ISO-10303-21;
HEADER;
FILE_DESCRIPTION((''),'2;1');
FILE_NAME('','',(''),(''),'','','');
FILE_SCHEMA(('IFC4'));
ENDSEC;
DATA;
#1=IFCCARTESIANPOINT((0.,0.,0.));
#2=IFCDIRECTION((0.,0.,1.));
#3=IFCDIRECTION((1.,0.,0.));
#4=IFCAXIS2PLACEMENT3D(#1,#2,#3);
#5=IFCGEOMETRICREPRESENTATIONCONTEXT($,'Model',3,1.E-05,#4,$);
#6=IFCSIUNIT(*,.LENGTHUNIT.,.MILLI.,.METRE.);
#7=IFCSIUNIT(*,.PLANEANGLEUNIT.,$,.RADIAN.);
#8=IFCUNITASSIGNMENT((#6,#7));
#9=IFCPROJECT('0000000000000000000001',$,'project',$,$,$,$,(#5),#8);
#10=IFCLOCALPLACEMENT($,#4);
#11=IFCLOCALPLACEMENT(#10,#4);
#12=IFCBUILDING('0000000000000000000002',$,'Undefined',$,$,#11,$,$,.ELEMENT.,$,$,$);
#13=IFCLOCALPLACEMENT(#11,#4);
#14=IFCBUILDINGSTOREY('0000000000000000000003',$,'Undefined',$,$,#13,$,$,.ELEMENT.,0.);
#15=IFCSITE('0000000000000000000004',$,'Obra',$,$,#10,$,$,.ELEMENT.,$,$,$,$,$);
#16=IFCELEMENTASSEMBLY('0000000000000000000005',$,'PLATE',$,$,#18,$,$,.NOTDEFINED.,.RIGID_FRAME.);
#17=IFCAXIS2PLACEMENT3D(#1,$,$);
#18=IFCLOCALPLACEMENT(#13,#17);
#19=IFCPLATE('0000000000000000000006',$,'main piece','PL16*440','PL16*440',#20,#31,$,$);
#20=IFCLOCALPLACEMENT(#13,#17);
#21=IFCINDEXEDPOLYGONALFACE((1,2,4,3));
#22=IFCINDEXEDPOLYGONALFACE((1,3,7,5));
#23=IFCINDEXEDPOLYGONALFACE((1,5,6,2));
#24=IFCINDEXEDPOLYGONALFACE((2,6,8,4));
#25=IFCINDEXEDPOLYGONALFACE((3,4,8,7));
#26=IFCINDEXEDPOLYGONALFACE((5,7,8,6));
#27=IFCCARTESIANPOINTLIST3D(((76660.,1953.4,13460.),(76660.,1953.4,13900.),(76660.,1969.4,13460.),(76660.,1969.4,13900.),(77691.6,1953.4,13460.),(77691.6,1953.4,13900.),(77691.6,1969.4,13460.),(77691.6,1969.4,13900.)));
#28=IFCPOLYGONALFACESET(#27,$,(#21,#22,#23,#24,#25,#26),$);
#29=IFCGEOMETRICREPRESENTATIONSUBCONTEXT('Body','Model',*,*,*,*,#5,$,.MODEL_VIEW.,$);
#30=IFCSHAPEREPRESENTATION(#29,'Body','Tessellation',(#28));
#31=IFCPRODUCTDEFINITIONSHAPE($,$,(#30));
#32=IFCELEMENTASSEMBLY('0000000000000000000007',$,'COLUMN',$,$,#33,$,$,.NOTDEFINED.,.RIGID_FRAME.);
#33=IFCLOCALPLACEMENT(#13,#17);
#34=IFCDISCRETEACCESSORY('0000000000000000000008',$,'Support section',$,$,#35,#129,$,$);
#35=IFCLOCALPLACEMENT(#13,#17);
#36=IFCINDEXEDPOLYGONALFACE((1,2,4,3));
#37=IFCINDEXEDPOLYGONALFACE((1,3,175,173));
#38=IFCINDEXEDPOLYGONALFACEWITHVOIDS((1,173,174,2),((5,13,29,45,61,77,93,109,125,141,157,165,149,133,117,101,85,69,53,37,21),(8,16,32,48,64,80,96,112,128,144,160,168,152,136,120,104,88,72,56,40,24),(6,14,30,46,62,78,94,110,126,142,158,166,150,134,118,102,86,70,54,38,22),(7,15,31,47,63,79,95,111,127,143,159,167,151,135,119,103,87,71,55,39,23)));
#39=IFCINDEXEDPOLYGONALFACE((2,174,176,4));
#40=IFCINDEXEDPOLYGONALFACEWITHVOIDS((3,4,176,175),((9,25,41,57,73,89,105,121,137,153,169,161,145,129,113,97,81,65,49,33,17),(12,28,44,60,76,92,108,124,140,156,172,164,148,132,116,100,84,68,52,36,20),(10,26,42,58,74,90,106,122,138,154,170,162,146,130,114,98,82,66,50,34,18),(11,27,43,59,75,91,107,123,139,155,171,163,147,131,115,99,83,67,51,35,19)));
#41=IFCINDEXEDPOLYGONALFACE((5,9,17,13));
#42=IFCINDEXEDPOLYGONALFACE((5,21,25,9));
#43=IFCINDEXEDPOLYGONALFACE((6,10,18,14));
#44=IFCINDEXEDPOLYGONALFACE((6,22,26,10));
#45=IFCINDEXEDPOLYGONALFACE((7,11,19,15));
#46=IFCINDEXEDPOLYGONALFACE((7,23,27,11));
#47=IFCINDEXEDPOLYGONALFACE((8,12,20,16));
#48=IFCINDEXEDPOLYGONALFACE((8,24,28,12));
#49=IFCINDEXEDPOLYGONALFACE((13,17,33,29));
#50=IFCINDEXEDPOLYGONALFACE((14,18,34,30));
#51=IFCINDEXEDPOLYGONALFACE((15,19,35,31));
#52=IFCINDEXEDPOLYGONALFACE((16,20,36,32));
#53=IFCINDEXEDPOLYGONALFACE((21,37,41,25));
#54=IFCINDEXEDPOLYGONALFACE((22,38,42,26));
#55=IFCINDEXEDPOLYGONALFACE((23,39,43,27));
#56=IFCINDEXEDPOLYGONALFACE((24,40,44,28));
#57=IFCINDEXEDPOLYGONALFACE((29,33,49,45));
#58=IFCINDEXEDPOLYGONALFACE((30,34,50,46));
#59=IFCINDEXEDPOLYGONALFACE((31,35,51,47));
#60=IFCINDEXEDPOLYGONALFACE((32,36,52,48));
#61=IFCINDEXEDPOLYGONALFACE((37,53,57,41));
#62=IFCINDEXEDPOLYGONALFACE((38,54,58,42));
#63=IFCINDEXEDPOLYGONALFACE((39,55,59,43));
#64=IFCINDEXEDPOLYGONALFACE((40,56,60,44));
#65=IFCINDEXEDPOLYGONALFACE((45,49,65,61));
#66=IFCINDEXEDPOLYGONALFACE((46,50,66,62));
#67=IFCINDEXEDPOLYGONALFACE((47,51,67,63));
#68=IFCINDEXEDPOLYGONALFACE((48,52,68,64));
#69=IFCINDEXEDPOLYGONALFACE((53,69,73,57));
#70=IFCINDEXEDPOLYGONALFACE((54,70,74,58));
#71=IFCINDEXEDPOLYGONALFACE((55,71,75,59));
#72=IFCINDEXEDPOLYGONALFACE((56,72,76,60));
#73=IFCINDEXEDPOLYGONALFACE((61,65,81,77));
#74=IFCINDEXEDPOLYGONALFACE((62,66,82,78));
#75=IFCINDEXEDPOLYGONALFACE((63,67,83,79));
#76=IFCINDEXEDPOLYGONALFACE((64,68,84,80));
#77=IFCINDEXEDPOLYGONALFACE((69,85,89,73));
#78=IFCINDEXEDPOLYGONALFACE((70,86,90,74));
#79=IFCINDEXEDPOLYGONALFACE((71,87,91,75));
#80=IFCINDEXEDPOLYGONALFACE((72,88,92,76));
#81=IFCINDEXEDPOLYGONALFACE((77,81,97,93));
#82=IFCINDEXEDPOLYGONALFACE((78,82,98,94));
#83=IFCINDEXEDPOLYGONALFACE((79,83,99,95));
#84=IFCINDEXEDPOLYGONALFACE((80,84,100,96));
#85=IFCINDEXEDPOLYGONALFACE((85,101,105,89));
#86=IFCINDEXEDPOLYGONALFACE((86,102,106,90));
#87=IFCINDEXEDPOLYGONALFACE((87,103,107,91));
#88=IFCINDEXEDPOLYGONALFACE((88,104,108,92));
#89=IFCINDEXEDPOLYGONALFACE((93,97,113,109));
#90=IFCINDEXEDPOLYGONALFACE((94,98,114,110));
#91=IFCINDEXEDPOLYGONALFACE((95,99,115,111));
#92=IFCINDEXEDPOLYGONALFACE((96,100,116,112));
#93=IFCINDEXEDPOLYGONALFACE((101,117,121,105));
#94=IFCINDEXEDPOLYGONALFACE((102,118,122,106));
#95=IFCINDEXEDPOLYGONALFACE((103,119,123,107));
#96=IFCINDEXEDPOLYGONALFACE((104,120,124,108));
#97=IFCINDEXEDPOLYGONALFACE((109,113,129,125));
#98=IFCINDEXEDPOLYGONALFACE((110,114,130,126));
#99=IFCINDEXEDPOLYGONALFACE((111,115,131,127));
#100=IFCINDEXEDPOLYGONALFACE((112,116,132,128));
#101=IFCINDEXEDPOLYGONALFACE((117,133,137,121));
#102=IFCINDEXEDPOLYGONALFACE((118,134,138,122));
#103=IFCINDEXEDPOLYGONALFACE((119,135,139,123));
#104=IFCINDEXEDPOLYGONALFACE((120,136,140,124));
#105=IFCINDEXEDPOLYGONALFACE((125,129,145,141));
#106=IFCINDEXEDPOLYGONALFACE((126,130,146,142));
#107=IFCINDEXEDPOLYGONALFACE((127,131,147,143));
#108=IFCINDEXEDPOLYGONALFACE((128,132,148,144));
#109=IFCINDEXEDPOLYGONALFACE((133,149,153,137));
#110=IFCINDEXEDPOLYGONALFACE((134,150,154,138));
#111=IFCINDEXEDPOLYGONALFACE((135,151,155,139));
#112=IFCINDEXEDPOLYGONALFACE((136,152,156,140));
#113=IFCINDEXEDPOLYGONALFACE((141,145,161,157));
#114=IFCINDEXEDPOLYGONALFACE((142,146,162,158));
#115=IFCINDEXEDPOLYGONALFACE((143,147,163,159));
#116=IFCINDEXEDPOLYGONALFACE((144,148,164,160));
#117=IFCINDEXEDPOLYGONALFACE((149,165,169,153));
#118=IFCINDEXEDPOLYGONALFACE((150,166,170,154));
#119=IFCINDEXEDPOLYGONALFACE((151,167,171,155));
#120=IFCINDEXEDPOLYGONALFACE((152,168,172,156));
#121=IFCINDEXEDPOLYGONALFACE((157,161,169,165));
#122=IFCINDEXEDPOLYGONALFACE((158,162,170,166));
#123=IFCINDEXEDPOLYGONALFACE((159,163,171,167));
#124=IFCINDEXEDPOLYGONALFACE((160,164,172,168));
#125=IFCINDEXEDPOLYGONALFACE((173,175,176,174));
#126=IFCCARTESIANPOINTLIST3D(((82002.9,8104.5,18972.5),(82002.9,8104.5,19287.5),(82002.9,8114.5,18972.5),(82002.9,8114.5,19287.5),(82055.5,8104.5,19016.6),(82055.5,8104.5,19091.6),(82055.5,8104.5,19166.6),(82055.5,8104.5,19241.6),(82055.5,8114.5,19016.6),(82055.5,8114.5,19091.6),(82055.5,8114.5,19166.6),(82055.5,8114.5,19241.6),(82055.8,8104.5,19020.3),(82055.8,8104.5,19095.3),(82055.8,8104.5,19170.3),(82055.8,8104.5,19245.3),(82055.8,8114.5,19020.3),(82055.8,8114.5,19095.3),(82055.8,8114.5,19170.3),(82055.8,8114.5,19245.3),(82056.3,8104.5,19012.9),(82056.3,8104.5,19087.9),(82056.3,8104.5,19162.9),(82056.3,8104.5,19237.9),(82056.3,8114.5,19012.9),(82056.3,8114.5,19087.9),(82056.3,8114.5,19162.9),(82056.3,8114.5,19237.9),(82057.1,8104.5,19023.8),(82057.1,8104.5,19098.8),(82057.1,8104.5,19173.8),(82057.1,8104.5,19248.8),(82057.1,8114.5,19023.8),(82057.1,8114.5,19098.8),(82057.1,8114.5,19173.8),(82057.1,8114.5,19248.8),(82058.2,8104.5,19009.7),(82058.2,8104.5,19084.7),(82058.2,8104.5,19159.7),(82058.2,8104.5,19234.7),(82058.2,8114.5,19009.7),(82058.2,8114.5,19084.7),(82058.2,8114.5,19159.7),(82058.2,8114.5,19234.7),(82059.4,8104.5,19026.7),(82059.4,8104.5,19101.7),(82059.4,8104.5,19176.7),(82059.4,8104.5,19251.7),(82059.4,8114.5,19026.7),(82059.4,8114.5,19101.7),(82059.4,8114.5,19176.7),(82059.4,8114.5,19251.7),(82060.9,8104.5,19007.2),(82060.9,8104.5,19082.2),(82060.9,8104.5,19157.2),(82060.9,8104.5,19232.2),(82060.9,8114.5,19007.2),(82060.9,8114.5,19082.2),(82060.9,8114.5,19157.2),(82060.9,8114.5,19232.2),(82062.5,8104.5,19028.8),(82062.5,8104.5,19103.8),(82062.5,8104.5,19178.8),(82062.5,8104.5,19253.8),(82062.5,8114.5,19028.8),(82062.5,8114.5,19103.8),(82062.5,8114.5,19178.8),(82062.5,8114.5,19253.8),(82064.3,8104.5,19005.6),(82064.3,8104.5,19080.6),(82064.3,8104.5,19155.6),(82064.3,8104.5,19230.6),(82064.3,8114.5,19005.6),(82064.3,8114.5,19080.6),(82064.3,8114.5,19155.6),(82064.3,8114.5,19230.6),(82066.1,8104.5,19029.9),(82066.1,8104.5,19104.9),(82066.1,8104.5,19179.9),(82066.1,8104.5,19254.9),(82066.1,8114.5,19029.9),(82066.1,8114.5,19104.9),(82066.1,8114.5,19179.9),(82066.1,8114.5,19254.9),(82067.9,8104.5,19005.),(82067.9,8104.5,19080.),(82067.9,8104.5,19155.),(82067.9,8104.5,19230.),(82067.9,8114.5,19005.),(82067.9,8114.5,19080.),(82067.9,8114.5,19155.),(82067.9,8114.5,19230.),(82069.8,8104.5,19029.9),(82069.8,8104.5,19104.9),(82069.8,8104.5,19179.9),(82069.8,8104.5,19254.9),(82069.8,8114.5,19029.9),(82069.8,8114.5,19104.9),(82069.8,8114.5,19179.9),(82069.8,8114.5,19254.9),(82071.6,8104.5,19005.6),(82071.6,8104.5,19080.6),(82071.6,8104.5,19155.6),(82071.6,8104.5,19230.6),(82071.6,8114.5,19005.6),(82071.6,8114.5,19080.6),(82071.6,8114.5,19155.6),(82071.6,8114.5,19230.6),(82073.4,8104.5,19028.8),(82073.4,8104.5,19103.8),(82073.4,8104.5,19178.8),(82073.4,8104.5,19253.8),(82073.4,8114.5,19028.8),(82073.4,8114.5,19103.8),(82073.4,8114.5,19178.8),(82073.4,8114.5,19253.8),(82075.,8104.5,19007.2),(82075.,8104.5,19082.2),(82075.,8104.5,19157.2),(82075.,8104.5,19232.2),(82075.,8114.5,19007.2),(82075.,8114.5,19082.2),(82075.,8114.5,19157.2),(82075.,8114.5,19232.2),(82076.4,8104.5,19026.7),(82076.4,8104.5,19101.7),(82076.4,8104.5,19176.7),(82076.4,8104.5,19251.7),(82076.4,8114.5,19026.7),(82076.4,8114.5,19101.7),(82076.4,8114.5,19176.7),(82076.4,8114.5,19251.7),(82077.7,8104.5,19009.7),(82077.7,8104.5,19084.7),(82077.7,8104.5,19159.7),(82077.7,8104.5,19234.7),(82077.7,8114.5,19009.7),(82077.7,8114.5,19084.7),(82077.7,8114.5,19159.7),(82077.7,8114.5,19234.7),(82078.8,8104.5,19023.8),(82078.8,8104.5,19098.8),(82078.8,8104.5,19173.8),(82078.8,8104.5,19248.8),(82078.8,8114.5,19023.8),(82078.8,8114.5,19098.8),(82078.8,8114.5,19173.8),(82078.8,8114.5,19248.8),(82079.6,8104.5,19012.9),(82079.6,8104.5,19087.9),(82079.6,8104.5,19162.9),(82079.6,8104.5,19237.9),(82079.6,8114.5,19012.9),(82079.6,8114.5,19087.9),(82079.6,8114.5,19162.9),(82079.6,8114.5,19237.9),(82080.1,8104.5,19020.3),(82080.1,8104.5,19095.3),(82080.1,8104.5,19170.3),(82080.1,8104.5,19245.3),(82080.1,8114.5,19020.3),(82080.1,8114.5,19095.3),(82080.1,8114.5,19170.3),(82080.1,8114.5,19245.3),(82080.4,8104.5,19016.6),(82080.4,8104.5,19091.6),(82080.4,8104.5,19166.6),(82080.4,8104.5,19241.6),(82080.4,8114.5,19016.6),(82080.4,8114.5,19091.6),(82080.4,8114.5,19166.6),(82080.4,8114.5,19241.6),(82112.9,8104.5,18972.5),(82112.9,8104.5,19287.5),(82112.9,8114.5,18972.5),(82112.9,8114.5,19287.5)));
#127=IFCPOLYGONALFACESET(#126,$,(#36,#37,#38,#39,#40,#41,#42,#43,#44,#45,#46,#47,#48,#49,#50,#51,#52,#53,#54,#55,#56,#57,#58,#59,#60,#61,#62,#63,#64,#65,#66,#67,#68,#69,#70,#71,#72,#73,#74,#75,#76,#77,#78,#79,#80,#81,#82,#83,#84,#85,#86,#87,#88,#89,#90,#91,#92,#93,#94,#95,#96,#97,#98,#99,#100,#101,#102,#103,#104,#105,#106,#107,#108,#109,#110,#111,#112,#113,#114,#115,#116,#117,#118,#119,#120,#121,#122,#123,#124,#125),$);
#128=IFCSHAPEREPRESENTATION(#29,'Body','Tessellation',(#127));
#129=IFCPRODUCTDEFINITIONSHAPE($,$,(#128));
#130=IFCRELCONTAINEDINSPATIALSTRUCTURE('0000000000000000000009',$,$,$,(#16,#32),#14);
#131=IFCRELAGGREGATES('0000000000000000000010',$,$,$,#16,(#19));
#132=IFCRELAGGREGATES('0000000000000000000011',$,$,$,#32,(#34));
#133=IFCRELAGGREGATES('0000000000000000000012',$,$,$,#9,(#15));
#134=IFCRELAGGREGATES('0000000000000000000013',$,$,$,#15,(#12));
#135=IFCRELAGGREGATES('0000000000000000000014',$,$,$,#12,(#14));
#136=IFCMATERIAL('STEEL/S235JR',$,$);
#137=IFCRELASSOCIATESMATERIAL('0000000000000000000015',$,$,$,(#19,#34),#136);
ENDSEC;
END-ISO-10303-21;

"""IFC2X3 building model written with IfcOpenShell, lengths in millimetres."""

from ifc_helpers import new_model, si_unit, frame, origin_with_axes, origin_2d_with_axis, place, context, subcontext, project, spatial, polyline, rectangle, circle, outline, extrude, source, transform, mapped, material, element, aggregate, save


model = new_model("IFC2X3")

# Units and contexts
model_context = context("Model", 3, precision=1e-05, world=origin_with_axes())
body_context = subcontext(model_context, "Body", "Model", "MODEL_VIEW")
ifc_project = project(units=[si_unit("LENGTHUNIT", "METRE", prefix="MILLI"), si_unit("PLANEANGLEUNIT", "RADIAN")], contexts=[model_context])

# Site, building, storey
site_placement = place(None, origin_with_axes())
site = spatial("IfcSite", under=ifc_project, at=site_placement, Name="Obra", CompositionType="ELEMENT")
building_placement = place(site_placement, origin_with_axes())
building = spatial("IfcBuilding", under=site, at=building_placement, Name="Undefined", CompositionType="ELEMENT")
storey_placement = place(building_placement, origin_with_axes())
storey = spatial("IfcBuildingStorey", under=building, at=storey_placement, Name="Undefined", CompositionType="ELEMENT", Elevation=0.0)

# Shared definitions
ifc_material_1 = material(Name="STEEL/S235JR")

# Element assembly, plate
assembly_1_placement = place(storey_placement, origin_with_axes())
assembly_1 = element("IfcElementAssembly", 1, at=assembly_1_placement, inside=storey, Name="PLATE", AssemblyPlace="NOTDEFINED", PredefinedType="RIGID_FRAME")
plate_placement = place(assembly_1_placement, frame((77691.6, 1961.4, 13900.0), z_axis=(0.0, 1.0, 0.0), x_axis=(0.0, 0.0, -1.0)))
plate = element("IfcPlate", 2, at=plate_placement, material=ifc_material_1, Name="main piece", Description="PL16*440", ObjectType="PL16*440", context=body_context, shape_type="SweptSolid", body=[
    extrude(outline(polyline([(0.0, 0.0), (440.0, 0.0), (440.0, 1031.6), (0.0, 1031.6), (0.0, 0.0)])), frame((0.0, 0.0, -8.0), z_axis=(0.0, 0.0, 1.0), x_axis=(1.0, 0.0, 0.0)), (0.0, 0.0, 1.0), 16.0),
])
aggregate(assembly_1, [plate])

# Element assembly, discrete accessory, opening
assembly_2_placement = place(storey_placement, origin_with_axes())
assembly_2 = element("IfcElementAssembly", 3, at=assembly_2_placement, inside=storey, Name="COLUMN", AssemblyPlace="NOTDEFINED", PredefinedType="RIGID_FRAME")
discrete_accessory_1_placement = place(assembly_2_placement, frame((82057.9, 8109.5, 18972.5), z_axis=(0.0, 0.0, 1.0), x_axis=(-1.0, 0.0, 0.0)))
discrete_accessory_1 = element("IfcDiscreteAccessory", 4, at=discrete_accessory_1_placement, material=ifc_material_1, Name="Support section", context=body_context, shape_type="SweptSolid", body=[
    extrude(rectangle(XDim=10.0, YDim=110.0, at=origin_2d_with_axis()), frame((0.0, 0.0, 315.0), z_axis=(0.0, 0.0, -1.0), x_axis=(0.0, 1.0, 0.0)), (0.0, 0.0, 1.0), 315.0),
])
shared_shape_1 = source(origin_with_axes(), body_context, "Body", "SweptSolid", [
    extrude(circle(Radius=12.5, at=origin_2d_with_axis()), frame((0.0, -15.8, 0.0), z_axis=(0.0, 1.0, 0.0), x_axis=(1.0, 0.0, 0.0)), (0.0, 0.0, 1.0), 10.2),
])
opening_1_placement = place(assembly_2_placement, frame((82022.9, 8120.2, 19350.0), z_axis=(1.0, 0.0, 0.0), x_axis=(0.0, 0.0, -1.0)))
element("IfcOpeningElement", 5, at=opening_1_placement, cuts=discrete_accessory_1, ObjectType="Opening", context=body_context, shape_type="MappedRepresentation", body=[
    mapped(shared_shape_1, transform((107.5, 0.0, 45.0))),
    mapped(shared_shape_1, transform((182.5, 0.0, 45.0))),
    mapped(shared_shape_1, transform((257.5, 0.0, 45.0))),
    mapped(shared_shape_1, transform((332.5, 0.0, 45.0))),
])
aggregate(assembly_2, [discrete_accessory_1])

save(model, "model.ifc")
